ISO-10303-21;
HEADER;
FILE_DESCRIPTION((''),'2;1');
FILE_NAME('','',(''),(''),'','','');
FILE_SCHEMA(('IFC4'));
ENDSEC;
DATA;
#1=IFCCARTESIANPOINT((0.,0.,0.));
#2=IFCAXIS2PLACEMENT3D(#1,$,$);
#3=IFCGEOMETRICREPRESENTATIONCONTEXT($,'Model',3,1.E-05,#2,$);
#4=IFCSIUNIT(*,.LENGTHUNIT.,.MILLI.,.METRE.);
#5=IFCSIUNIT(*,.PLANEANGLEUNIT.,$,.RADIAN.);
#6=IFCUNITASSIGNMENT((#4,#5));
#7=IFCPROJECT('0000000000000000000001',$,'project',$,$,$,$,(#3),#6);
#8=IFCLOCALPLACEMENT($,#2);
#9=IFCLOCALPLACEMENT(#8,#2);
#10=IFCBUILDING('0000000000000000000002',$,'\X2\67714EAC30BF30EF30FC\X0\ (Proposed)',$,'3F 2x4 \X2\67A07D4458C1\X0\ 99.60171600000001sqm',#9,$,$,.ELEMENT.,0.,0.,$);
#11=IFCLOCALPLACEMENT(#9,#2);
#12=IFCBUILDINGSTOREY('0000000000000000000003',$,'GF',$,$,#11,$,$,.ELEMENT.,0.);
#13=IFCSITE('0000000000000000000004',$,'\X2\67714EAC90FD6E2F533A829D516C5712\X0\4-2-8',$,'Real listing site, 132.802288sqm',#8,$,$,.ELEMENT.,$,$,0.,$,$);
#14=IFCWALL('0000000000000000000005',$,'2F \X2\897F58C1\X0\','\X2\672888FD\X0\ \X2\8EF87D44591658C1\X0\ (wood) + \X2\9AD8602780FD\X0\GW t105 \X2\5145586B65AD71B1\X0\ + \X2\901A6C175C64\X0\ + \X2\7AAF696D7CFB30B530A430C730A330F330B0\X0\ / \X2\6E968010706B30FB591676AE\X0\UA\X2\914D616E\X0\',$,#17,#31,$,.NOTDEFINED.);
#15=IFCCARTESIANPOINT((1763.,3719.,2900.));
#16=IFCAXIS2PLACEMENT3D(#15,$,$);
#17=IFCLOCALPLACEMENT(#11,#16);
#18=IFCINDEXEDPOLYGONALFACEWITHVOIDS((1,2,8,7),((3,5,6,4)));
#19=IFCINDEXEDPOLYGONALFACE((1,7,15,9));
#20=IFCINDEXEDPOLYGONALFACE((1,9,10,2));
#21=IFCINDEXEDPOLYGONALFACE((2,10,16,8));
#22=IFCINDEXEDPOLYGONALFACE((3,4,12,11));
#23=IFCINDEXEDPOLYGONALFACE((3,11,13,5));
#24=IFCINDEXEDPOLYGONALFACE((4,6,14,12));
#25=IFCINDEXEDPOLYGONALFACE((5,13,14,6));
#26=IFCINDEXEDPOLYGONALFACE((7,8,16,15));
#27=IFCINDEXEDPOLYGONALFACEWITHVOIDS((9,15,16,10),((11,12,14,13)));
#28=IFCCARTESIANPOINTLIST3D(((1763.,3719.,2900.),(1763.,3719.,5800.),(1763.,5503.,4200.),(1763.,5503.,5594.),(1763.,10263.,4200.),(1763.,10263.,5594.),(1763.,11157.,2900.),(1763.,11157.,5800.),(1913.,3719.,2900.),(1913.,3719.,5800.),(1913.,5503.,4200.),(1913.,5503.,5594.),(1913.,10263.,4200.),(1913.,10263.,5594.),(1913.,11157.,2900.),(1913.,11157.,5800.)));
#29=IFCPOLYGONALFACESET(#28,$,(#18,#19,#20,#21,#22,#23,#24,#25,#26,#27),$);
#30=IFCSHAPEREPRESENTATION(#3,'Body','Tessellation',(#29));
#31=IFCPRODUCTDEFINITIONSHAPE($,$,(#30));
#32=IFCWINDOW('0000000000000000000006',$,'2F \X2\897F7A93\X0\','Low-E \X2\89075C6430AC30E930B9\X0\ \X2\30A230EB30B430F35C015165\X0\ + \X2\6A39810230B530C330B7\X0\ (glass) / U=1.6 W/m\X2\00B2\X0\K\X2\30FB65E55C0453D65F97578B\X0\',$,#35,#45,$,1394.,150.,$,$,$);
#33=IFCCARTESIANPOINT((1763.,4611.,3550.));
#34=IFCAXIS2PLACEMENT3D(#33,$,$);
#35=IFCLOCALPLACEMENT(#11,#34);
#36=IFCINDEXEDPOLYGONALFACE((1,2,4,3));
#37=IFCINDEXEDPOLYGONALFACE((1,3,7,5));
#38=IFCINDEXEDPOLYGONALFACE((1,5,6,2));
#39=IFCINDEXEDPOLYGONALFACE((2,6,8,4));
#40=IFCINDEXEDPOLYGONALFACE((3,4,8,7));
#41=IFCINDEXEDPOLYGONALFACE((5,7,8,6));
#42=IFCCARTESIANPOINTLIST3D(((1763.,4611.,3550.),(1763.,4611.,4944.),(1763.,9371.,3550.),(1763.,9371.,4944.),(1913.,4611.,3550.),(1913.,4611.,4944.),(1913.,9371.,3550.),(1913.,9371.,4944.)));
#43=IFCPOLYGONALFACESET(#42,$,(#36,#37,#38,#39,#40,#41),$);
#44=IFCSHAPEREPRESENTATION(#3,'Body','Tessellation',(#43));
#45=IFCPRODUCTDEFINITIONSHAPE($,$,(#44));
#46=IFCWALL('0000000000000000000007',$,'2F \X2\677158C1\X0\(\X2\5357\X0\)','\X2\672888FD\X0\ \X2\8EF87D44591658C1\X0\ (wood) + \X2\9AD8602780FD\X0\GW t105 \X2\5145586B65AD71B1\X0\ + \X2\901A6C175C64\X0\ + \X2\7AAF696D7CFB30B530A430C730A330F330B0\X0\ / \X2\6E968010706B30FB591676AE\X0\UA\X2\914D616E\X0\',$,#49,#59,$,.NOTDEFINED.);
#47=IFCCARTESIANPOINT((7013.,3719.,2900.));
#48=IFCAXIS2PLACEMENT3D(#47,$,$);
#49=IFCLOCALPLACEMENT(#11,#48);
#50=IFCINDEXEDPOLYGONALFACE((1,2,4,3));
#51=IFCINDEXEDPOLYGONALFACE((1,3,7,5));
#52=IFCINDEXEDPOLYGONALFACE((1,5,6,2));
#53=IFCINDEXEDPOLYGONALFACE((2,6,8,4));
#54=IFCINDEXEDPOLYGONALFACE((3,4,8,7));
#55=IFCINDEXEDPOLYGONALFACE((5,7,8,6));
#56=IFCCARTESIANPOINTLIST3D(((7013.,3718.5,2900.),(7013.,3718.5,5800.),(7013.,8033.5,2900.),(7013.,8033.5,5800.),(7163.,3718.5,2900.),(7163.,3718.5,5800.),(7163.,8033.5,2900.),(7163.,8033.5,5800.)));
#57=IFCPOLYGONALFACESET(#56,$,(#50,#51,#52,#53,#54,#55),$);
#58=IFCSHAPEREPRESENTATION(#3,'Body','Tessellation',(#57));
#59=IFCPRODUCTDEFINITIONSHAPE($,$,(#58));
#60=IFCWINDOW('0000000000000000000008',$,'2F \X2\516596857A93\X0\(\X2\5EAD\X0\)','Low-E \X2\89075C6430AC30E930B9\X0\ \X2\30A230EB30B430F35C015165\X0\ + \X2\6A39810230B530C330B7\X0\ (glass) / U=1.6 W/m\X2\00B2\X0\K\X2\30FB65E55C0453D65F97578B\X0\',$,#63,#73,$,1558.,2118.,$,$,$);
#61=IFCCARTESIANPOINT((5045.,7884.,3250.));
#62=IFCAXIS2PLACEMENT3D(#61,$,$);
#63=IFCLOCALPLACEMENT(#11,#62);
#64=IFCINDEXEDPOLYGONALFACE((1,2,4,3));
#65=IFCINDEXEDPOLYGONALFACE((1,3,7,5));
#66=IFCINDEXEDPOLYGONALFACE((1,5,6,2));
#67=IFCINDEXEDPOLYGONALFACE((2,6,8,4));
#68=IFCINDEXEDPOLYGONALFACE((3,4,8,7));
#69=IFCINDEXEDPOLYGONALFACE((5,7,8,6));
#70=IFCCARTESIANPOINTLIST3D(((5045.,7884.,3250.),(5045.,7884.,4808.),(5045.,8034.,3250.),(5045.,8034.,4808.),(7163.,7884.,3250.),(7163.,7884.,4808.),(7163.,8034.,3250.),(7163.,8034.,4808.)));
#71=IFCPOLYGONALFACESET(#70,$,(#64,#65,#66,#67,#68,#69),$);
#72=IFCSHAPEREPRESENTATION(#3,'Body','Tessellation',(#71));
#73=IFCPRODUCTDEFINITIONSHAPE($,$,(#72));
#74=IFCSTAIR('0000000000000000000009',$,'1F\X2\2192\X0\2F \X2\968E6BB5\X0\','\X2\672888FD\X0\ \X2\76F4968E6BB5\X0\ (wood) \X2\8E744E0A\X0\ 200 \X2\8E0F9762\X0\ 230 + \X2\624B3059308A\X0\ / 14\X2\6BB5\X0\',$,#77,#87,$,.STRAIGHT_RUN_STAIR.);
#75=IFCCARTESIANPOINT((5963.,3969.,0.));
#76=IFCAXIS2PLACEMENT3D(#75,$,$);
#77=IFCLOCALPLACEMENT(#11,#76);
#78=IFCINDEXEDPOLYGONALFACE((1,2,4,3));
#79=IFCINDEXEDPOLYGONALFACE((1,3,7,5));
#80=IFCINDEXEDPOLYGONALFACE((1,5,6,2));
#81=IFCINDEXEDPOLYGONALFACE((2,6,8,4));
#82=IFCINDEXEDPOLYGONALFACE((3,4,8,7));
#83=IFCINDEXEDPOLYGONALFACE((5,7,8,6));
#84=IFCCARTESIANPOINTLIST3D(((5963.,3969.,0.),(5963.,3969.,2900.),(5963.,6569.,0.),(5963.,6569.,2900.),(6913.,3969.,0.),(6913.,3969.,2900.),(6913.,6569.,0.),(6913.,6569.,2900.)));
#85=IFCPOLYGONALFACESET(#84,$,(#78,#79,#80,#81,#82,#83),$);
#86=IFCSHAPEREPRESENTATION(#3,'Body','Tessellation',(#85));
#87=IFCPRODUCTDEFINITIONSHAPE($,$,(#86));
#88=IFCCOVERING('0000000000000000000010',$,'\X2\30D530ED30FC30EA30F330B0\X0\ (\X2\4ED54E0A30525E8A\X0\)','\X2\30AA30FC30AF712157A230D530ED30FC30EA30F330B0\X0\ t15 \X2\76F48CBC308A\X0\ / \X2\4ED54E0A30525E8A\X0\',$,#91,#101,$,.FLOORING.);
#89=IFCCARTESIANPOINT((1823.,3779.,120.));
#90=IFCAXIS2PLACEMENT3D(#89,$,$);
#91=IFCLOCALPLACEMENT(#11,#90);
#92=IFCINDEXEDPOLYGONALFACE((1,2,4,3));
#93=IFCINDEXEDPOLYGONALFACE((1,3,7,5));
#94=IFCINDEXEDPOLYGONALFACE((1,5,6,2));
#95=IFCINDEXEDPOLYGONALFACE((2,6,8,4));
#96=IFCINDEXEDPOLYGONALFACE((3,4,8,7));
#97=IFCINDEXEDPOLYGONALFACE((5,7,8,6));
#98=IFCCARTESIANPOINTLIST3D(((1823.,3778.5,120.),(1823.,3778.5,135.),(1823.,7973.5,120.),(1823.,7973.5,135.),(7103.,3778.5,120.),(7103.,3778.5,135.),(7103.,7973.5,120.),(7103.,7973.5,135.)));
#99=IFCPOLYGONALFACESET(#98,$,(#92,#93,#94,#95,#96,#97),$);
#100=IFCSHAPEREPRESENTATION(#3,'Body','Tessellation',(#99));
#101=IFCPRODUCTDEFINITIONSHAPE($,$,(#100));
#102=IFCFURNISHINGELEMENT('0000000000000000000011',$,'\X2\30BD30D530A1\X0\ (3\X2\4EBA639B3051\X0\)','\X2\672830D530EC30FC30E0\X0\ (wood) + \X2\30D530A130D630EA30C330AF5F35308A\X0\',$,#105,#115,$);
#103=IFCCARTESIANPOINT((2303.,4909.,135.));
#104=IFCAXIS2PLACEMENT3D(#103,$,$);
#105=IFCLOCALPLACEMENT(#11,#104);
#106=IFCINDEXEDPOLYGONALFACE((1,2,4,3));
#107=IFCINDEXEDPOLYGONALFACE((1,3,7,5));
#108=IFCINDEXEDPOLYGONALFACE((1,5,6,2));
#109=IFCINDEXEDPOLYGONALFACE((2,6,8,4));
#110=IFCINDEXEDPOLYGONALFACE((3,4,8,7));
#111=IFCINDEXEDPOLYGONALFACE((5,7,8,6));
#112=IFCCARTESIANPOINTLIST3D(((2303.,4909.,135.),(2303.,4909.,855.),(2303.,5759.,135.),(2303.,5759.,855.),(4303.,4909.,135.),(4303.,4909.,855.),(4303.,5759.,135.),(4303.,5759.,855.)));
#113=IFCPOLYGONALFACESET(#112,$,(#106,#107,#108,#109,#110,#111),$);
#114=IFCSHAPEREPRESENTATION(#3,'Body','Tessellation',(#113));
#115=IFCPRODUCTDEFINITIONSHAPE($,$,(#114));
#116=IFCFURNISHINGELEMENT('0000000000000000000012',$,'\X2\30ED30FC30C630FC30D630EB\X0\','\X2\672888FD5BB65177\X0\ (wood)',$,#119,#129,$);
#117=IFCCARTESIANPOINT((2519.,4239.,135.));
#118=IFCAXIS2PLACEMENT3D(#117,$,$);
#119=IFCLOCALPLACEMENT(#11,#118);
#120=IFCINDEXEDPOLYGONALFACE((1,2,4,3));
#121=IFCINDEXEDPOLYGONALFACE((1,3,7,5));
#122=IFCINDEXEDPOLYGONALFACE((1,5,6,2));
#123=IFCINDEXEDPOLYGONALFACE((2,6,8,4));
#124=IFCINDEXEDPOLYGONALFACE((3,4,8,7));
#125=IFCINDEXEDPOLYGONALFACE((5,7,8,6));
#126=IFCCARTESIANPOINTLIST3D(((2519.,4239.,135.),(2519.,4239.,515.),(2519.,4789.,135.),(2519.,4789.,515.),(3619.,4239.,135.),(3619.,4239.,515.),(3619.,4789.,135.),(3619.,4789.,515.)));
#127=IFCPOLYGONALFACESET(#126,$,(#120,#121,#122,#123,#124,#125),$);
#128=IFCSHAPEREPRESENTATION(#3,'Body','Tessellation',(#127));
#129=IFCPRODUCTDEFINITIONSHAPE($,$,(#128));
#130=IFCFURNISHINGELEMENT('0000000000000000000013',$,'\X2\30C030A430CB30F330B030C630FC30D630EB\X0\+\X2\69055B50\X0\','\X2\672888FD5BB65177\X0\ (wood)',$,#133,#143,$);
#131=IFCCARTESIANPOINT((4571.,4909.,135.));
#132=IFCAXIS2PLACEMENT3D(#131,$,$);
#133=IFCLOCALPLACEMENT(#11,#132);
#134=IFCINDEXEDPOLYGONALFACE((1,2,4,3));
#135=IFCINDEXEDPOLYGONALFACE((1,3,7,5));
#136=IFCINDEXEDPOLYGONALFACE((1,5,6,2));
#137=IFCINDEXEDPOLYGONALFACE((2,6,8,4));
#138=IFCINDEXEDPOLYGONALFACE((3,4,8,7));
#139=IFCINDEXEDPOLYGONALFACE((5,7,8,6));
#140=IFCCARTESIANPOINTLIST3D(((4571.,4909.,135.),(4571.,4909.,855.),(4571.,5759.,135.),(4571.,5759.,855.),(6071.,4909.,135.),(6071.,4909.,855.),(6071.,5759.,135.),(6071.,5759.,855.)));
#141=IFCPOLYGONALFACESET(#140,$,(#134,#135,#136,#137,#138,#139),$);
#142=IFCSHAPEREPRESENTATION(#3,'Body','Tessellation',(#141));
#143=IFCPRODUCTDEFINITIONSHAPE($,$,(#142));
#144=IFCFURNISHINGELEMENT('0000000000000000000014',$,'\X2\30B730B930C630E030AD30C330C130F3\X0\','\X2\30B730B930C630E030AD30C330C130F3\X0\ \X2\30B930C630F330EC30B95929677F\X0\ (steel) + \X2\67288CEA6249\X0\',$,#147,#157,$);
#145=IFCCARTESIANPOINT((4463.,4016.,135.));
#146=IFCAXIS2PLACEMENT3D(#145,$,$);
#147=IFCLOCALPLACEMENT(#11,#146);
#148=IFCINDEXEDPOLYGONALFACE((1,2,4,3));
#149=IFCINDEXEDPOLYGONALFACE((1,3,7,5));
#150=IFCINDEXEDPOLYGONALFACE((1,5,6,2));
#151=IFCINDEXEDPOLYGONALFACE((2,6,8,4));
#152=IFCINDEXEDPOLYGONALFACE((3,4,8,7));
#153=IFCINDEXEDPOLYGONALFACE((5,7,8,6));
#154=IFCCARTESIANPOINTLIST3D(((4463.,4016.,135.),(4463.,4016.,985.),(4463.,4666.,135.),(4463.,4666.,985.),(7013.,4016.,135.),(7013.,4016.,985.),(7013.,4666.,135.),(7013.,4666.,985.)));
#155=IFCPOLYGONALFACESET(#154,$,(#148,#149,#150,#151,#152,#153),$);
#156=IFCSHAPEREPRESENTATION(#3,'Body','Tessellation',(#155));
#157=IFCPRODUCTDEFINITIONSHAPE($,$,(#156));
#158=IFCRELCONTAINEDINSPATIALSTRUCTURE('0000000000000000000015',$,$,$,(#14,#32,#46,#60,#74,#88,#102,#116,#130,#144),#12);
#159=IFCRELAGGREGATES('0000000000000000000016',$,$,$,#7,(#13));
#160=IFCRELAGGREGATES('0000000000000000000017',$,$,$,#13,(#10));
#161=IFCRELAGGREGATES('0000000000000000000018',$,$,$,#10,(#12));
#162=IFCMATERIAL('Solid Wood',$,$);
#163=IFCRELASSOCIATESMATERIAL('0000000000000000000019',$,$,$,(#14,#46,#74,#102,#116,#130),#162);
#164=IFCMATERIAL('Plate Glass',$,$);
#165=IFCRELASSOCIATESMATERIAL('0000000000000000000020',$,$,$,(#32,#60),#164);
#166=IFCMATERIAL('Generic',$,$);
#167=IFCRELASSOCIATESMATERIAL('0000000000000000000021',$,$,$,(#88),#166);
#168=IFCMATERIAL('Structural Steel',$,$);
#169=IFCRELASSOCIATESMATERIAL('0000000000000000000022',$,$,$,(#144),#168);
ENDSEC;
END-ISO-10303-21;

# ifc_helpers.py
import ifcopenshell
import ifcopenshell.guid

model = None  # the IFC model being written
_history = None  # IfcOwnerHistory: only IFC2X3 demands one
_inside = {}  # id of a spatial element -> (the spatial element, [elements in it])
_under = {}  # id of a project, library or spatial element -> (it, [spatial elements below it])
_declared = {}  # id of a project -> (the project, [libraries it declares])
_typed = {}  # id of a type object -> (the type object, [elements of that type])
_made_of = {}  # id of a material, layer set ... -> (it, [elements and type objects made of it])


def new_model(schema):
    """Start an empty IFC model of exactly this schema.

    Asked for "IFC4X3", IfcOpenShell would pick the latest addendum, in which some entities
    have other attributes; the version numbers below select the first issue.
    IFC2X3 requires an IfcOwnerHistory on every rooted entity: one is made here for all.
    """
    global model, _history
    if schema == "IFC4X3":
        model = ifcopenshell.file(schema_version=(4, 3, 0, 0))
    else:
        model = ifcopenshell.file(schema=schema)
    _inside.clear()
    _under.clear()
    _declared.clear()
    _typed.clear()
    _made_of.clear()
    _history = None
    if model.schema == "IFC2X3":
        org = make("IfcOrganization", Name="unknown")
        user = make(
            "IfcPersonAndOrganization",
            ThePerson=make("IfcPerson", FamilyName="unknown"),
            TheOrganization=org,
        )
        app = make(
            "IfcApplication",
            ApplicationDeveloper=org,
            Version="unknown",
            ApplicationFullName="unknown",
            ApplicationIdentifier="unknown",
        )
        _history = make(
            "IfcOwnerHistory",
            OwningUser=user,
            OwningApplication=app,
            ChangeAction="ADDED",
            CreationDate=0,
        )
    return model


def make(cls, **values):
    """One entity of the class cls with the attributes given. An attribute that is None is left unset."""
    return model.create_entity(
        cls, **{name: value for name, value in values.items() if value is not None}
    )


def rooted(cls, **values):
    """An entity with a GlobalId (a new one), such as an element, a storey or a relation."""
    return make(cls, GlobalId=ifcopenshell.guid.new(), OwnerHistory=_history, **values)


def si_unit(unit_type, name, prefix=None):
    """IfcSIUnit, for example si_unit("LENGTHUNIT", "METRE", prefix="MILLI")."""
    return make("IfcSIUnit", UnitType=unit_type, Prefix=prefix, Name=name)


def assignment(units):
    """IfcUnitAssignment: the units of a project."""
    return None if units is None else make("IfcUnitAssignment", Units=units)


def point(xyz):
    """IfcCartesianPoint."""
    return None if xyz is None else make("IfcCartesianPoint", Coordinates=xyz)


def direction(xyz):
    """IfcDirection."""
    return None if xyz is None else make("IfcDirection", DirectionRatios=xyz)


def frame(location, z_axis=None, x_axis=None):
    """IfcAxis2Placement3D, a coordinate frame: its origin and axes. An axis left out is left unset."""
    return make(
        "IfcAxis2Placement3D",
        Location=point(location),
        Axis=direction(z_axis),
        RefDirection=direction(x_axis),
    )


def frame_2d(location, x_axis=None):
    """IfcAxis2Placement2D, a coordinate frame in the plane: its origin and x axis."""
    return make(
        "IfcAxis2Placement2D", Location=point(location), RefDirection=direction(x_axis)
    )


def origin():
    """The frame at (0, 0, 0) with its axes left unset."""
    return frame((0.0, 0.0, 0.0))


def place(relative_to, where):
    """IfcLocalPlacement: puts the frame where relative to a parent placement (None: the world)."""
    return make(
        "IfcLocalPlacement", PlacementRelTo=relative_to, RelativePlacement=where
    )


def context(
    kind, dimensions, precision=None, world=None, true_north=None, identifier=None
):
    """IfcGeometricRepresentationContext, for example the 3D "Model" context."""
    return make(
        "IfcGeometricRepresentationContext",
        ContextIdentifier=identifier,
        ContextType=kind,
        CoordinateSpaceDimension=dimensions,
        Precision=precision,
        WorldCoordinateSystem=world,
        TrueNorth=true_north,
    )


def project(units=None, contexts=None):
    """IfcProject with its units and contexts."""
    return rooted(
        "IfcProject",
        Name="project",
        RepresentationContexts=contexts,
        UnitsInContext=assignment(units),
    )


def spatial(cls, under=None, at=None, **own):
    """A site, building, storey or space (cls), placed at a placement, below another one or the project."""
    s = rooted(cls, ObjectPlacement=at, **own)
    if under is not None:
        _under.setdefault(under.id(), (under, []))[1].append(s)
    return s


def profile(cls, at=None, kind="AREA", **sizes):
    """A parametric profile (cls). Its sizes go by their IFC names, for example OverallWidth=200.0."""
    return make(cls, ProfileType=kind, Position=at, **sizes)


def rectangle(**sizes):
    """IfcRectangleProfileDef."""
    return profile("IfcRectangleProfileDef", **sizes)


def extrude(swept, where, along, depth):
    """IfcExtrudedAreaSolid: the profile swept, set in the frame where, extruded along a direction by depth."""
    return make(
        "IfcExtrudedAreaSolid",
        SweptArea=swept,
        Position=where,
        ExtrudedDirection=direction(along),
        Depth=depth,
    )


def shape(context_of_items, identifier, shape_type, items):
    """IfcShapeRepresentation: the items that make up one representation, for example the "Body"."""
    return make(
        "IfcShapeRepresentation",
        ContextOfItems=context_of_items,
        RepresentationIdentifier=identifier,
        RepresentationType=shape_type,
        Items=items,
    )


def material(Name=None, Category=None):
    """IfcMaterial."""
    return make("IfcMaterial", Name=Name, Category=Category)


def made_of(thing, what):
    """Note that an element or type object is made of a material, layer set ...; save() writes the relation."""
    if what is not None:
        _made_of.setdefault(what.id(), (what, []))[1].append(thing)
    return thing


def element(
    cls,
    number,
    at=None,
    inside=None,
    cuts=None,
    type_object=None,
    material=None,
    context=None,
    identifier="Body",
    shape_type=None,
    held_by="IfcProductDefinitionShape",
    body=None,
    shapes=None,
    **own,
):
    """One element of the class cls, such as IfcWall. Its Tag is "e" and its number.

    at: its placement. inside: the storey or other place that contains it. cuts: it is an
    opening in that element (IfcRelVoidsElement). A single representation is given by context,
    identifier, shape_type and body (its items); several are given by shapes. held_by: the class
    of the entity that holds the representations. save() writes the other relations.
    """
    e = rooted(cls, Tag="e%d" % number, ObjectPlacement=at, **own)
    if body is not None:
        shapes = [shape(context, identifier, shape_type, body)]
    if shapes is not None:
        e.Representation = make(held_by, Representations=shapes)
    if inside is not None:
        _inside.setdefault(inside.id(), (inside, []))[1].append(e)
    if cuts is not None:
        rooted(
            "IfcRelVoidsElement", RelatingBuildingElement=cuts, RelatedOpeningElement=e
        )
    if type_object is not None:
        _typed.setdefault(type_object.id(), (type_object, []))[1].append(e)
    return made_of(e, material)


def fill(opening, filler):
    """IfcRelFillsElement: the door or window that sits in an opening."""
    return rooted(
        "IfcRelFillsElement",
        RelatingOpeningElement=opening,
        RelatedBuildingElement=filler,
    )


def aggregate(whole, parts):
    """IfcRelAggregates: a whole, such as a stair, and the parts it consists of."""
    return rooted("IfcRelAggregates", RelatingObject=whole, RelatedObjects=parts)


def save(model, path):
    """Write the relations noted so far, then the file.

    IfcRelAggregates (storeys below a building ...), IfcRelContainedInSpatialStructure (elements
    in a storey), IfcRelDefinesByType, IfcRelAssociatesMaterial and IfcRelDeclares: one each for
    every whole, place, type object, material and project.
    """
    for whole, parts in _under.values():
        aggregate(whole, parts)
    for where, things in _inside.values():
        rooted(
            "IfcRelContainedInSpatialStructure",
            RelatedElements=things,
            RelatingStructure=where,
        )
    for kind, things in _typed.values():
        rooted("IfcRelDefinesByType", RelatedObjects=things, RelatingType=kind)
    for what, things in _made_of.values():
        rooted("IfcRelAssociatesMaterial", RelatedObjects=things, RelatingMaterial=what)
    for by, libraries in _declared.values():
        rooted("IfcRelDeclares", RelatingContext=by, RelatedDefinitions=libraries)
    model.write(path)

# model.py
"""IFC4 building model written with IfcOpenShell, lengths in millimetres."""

from ifc_helpers import new_model, si_unit, frame, frame_2d, origin, place, context, project, spatial, rectangle, extrude, material, element, fill, save


model = new_model("IFC4")

# Units and contexts
model_context = context("Model", 3, precision=1e-05, world=origin())
ifc_project = project(units=[si_unit("LENGTHUNIT", "METRE", prefix="MILLI"), si_unit("PLANEANGLEUNIT", "RADIAN")], contexts=[model_context])

# Site, building, storey
site_placement = place(None, origin())
site = spatial("IfcSite", under=ifc_project, at=site_placement, Name="東京都港区芝公園4-2-8", ObjectType="Real listing site, 132.802288sqm", CompositionType="ELEMENT", RefElevation=0.0)
building_placement = place(site_placement, origin())
building = spatial("IfcBuilding", under=site, at=building_placement, Name="東京タワー (Proposed)", ObjectType="3F 2x4 枠組壁 99.60171600000001sqm", CompositionType="ELEMENT", ElevationOfRefHeight=0.0, ElevationOfTerrain=0.0)
storey_placement = place(building_placement, origin())
storey = spatial("IfcBuildingStorey", under=building, at=storey_placement, Name="GF", CompositionType="ELEMENT", Elevation=0.0)

# Shared definitions
ifc_material_1 = material(Name="Solid Wood")

# Shared definitions
ifc_material_2 = material(Name="Plate Glass")

# Walls, openings, windows
wall_1_placement = place(storey_placement, frame((1763.0, 3719.0, 2900.0)))
wall_1 = element("IfcWall", 1, at=wall_1_placement, inside=storey, material=ifc_material_1, Name="2F 西壁", Description="木製 軸組外壁 (wood) + 高性能GW t105 充填断熱 + 通気層 + 窯業系サイディング / 準耐火・外皮UA配慮", PredefinedType="NOTDEFINED", context=model_context, shape_type="SweptSolid", body=[
    extrude(rectangle(XDim=150.0, YDim=7438.0, at=frame_2d((75.0, 3719.0))), frame((1763.0, 3719.0, 2900.0)), (0.0, 0.0, 1.0), 2900.0),
])
opening_1_placement = place(storey_placement, frame((1763.0, 4611.0, 3550.0)))
opening_1 = element("IfcOpeningElement", 2, at=opening_1_placement, cuts=wall_1, PredefinedType="NOTDEFINED", context=model_context, shape_type="SweptSolid", body=[
    extrude(rectangle(XDim=150.0, YDim=4760.0, at=frame_2d((75.0, 2380.0))), frame((1763.0, 4611.0, 3550.0)), (0.0, 0.0, 1.0), 1394.0),
])
window_1_placement = place(storey_placement, frame((1763.0, 4611.0, 3550.0)))
window_1 = element("IfcWindow", 3, at=window_1_placement, inside=storey, material=ifc_material_2, Name="2F 西窓", Description="Low-E 複層ガラス アルゴン封入 + 樹脂サッシ (glass) / U=1.6 W/m²K・日射取得型", OverallHeight=1394.0, OverallWidth=150.0, context=model_context, shape_type="SweptSolid", body=[
    extrude(rectangle(XDim=150.0, YDim=4760.0, at=frame_2d((75.0, 2380.0))), frame((1763.0, 4611.0, 3550.0)), (0.0, 0.0, 1.0), 1394.0),
])
fill(opening_1, window_1)
wall_2_placement = place(storey_placement, frame((7013.0, 3719.0, 2900.0)))
wall_2 = element("IfcWall", 4, at=wall_2_placement, inside=storey, material=ifc_material_1, Name="2F 東壁(南)", Description="木製 軸組外壁 (wood) + 高性能GW t105 充填断熱 + 通気層 + 窯業系サイディング / 準耐火・外皮UA配慮", PredefinedType="NOTDEFINED", context=model_context, shape_type="SweptSolid", body=[
    extrude(rectangle(XDim=150.0, YDim=4315.0, at=frame_2d((75.0, 2157.0))), frame((7013.0, 3719.0, 2900.0)), (0.0, 0.0, 1.0), 2900.0),
])
opening_2_placement = place(storey_placement, frame((5045.0, 7884.0, 3250.0)))
opening_2 = element("IfcOpeningElement", 5, at=opening_2_placement, cuts=wall_2, PredefinedType="NOTDEFINED", context=model_context, shape_type="SweptSolid", body=[
    extrude(rectangle(XDim=2118.0, YDim=150.0, at=frame_2d((1059.0, 75.0))), frame((5045.0, 7884.0, 3250.0)), (0.0, 0.0, 1.0), 1558.0),
])
window_2_placement = place(storey_placement, frame((5045.0, 7884.0, 3250.0)))
window_2 = element("IfcWindow", 6, at=window_2_placement, inside=storey, material=ifc_material_2, Name="2F 入隅窓(庭)", Description="Low-E 複層ガラス アルゴン封入 + 樹脂サッシ (glass) / U=1.6 W/m²K・日射取得型", OverallHeight=1558.0, OverallWidth=2118.0, context=model_context, shape_type="SweptSolid", body=[
    extrude(rectangle(XDim=2118.0, YDim=150.0, at=frame_2d((1059.0, 75.0))), frame((5045.0, 7884.0, 3250.0)), (0.0, 0.0, 1.0), 1558.0),
])
fill(opening_2, window_2)

# Stair
stair_placement = place(storey_placement, frame((5963.0, 3969.0, 0.0)))
element("IfcStair", 7, at=stair_placement, inside=storey, material=ifc_material_1, Name="1F→2F 階段", Description="木製 直階段 (wood) 蹴上 200 踏面 230 + 手すり / 14段", PredefinedType="STRAIGHT_RUN_STAIR", context=model_context, shape_type="SweptSolid", body=[
    extrude(rectangle(XDim=950.0, YDim=2600.0, at=frame_2d((475.0, 1300.0))), frame((5963.0, 3969.0, 0.0)), (0.0, 0.0, 1.0), 2900.0),
])

# Covering
ifc_material_3 = material(Name="Generic")
covering_placement = place(storey_placement, frame((1823.0, 3779.0, 120.0)))
element("IfcCovering", 8, at=covering_placement, inside=storey, material=ifc_material_3, Name="フローリング (仕上げ床)", Description="オーク無垢フローリング t15 直貼り / 仕上げ床", PredefinedType="FLOORING", context=model_context, shape_type="SweptSolid", body=[
    extrude(rectangle(XDim=5280.0, YDim=4195.0, at=frame_2d((2640.0, 2097.0))), frame((1823.0, 3779.0, 120.0)), (0.0, 0.0, 1.0), 15.0),
])

# Furnishing elements
furnishing_1_placement = place(storey_placement, frame((2303.0, 4909.0, 135.0)))
element("IfcFurnishingElement", 9, at=furnishing_1_placement, inside=storey, material=ifc_material_1, Name="ソファ (3人掛け)", Description="木フレーム (wood) + ファブリック張り", context=model_context, shape_type="SweptSolid", body=[
    extrude(rectangle(XDim=2000.0, YDim=850.0, at=frame_2d((1000.0, 425.0))), frame((2303.0, 4909.0, 135.0)), (0.0, 0.0, 1.0), 720.0),
])
furnishing_2_placement = place(storey_placement, frame((2519.0, 4239.0, 135.0)))
element("IfcFurnishingElement", 10, at=furnishing_2_placement, inside=storey, material=ifc_material_1, Name="ローテーブル", Description="木製家具 (wood)", context=model_context, shape_type="SweptSolid", body=[
    extrude(rectangle(XDim=1100.0, YDim=550.0, at=frame_2d((550.0, 275.0))), frame((2519.0, 4239.0, 135.0)), (0.0, 0.0, 1.0), 380.0),
])
furnishing_3_placement = place(storey_placement, frame((4571.0, 4909.0, 135.0)))
element("IfcFurnishingElement", 11, at=furnishing_3_placement, inside=storey, material=ifc_material_1, Name="ダイニングテーブル+椅子", Description="木製家具 (wood)", context=model_context, shape_type="SweptSolid", body=[
    extrude(rectangle(XDim=1500.0, YDim=850.0, at=frame_2d((750.0, 425.0))), frame((4571.0, 4909.0, 135.0)), (0.0, 0.0, 1.0), 720.0),
])
ifc_material_4 = material(Name="Structural Steel")
furnishing_4_placement = place(storey_placement, frame((4463.0, 4016.0, 135.0)))
element("IfcFurnishingElement", 12, at=furnishing_4_placement, inside=storey, material=ifc_material_4, Name="システムキッチン", Description="システムキッチン ステンレス天板 (steel) + 木質扉", context=model_context, shape_type="SweptSolid", body=[
    extrude(rectangle(XDim=2550.0, YDim=650.0, at=frame_2d((1275.0, 325.0))), frame((4463.0, 4016.0, 135.0)), (0.0, 0.0, 1.0), 850.0),
])

save(model, "model.ifc")
